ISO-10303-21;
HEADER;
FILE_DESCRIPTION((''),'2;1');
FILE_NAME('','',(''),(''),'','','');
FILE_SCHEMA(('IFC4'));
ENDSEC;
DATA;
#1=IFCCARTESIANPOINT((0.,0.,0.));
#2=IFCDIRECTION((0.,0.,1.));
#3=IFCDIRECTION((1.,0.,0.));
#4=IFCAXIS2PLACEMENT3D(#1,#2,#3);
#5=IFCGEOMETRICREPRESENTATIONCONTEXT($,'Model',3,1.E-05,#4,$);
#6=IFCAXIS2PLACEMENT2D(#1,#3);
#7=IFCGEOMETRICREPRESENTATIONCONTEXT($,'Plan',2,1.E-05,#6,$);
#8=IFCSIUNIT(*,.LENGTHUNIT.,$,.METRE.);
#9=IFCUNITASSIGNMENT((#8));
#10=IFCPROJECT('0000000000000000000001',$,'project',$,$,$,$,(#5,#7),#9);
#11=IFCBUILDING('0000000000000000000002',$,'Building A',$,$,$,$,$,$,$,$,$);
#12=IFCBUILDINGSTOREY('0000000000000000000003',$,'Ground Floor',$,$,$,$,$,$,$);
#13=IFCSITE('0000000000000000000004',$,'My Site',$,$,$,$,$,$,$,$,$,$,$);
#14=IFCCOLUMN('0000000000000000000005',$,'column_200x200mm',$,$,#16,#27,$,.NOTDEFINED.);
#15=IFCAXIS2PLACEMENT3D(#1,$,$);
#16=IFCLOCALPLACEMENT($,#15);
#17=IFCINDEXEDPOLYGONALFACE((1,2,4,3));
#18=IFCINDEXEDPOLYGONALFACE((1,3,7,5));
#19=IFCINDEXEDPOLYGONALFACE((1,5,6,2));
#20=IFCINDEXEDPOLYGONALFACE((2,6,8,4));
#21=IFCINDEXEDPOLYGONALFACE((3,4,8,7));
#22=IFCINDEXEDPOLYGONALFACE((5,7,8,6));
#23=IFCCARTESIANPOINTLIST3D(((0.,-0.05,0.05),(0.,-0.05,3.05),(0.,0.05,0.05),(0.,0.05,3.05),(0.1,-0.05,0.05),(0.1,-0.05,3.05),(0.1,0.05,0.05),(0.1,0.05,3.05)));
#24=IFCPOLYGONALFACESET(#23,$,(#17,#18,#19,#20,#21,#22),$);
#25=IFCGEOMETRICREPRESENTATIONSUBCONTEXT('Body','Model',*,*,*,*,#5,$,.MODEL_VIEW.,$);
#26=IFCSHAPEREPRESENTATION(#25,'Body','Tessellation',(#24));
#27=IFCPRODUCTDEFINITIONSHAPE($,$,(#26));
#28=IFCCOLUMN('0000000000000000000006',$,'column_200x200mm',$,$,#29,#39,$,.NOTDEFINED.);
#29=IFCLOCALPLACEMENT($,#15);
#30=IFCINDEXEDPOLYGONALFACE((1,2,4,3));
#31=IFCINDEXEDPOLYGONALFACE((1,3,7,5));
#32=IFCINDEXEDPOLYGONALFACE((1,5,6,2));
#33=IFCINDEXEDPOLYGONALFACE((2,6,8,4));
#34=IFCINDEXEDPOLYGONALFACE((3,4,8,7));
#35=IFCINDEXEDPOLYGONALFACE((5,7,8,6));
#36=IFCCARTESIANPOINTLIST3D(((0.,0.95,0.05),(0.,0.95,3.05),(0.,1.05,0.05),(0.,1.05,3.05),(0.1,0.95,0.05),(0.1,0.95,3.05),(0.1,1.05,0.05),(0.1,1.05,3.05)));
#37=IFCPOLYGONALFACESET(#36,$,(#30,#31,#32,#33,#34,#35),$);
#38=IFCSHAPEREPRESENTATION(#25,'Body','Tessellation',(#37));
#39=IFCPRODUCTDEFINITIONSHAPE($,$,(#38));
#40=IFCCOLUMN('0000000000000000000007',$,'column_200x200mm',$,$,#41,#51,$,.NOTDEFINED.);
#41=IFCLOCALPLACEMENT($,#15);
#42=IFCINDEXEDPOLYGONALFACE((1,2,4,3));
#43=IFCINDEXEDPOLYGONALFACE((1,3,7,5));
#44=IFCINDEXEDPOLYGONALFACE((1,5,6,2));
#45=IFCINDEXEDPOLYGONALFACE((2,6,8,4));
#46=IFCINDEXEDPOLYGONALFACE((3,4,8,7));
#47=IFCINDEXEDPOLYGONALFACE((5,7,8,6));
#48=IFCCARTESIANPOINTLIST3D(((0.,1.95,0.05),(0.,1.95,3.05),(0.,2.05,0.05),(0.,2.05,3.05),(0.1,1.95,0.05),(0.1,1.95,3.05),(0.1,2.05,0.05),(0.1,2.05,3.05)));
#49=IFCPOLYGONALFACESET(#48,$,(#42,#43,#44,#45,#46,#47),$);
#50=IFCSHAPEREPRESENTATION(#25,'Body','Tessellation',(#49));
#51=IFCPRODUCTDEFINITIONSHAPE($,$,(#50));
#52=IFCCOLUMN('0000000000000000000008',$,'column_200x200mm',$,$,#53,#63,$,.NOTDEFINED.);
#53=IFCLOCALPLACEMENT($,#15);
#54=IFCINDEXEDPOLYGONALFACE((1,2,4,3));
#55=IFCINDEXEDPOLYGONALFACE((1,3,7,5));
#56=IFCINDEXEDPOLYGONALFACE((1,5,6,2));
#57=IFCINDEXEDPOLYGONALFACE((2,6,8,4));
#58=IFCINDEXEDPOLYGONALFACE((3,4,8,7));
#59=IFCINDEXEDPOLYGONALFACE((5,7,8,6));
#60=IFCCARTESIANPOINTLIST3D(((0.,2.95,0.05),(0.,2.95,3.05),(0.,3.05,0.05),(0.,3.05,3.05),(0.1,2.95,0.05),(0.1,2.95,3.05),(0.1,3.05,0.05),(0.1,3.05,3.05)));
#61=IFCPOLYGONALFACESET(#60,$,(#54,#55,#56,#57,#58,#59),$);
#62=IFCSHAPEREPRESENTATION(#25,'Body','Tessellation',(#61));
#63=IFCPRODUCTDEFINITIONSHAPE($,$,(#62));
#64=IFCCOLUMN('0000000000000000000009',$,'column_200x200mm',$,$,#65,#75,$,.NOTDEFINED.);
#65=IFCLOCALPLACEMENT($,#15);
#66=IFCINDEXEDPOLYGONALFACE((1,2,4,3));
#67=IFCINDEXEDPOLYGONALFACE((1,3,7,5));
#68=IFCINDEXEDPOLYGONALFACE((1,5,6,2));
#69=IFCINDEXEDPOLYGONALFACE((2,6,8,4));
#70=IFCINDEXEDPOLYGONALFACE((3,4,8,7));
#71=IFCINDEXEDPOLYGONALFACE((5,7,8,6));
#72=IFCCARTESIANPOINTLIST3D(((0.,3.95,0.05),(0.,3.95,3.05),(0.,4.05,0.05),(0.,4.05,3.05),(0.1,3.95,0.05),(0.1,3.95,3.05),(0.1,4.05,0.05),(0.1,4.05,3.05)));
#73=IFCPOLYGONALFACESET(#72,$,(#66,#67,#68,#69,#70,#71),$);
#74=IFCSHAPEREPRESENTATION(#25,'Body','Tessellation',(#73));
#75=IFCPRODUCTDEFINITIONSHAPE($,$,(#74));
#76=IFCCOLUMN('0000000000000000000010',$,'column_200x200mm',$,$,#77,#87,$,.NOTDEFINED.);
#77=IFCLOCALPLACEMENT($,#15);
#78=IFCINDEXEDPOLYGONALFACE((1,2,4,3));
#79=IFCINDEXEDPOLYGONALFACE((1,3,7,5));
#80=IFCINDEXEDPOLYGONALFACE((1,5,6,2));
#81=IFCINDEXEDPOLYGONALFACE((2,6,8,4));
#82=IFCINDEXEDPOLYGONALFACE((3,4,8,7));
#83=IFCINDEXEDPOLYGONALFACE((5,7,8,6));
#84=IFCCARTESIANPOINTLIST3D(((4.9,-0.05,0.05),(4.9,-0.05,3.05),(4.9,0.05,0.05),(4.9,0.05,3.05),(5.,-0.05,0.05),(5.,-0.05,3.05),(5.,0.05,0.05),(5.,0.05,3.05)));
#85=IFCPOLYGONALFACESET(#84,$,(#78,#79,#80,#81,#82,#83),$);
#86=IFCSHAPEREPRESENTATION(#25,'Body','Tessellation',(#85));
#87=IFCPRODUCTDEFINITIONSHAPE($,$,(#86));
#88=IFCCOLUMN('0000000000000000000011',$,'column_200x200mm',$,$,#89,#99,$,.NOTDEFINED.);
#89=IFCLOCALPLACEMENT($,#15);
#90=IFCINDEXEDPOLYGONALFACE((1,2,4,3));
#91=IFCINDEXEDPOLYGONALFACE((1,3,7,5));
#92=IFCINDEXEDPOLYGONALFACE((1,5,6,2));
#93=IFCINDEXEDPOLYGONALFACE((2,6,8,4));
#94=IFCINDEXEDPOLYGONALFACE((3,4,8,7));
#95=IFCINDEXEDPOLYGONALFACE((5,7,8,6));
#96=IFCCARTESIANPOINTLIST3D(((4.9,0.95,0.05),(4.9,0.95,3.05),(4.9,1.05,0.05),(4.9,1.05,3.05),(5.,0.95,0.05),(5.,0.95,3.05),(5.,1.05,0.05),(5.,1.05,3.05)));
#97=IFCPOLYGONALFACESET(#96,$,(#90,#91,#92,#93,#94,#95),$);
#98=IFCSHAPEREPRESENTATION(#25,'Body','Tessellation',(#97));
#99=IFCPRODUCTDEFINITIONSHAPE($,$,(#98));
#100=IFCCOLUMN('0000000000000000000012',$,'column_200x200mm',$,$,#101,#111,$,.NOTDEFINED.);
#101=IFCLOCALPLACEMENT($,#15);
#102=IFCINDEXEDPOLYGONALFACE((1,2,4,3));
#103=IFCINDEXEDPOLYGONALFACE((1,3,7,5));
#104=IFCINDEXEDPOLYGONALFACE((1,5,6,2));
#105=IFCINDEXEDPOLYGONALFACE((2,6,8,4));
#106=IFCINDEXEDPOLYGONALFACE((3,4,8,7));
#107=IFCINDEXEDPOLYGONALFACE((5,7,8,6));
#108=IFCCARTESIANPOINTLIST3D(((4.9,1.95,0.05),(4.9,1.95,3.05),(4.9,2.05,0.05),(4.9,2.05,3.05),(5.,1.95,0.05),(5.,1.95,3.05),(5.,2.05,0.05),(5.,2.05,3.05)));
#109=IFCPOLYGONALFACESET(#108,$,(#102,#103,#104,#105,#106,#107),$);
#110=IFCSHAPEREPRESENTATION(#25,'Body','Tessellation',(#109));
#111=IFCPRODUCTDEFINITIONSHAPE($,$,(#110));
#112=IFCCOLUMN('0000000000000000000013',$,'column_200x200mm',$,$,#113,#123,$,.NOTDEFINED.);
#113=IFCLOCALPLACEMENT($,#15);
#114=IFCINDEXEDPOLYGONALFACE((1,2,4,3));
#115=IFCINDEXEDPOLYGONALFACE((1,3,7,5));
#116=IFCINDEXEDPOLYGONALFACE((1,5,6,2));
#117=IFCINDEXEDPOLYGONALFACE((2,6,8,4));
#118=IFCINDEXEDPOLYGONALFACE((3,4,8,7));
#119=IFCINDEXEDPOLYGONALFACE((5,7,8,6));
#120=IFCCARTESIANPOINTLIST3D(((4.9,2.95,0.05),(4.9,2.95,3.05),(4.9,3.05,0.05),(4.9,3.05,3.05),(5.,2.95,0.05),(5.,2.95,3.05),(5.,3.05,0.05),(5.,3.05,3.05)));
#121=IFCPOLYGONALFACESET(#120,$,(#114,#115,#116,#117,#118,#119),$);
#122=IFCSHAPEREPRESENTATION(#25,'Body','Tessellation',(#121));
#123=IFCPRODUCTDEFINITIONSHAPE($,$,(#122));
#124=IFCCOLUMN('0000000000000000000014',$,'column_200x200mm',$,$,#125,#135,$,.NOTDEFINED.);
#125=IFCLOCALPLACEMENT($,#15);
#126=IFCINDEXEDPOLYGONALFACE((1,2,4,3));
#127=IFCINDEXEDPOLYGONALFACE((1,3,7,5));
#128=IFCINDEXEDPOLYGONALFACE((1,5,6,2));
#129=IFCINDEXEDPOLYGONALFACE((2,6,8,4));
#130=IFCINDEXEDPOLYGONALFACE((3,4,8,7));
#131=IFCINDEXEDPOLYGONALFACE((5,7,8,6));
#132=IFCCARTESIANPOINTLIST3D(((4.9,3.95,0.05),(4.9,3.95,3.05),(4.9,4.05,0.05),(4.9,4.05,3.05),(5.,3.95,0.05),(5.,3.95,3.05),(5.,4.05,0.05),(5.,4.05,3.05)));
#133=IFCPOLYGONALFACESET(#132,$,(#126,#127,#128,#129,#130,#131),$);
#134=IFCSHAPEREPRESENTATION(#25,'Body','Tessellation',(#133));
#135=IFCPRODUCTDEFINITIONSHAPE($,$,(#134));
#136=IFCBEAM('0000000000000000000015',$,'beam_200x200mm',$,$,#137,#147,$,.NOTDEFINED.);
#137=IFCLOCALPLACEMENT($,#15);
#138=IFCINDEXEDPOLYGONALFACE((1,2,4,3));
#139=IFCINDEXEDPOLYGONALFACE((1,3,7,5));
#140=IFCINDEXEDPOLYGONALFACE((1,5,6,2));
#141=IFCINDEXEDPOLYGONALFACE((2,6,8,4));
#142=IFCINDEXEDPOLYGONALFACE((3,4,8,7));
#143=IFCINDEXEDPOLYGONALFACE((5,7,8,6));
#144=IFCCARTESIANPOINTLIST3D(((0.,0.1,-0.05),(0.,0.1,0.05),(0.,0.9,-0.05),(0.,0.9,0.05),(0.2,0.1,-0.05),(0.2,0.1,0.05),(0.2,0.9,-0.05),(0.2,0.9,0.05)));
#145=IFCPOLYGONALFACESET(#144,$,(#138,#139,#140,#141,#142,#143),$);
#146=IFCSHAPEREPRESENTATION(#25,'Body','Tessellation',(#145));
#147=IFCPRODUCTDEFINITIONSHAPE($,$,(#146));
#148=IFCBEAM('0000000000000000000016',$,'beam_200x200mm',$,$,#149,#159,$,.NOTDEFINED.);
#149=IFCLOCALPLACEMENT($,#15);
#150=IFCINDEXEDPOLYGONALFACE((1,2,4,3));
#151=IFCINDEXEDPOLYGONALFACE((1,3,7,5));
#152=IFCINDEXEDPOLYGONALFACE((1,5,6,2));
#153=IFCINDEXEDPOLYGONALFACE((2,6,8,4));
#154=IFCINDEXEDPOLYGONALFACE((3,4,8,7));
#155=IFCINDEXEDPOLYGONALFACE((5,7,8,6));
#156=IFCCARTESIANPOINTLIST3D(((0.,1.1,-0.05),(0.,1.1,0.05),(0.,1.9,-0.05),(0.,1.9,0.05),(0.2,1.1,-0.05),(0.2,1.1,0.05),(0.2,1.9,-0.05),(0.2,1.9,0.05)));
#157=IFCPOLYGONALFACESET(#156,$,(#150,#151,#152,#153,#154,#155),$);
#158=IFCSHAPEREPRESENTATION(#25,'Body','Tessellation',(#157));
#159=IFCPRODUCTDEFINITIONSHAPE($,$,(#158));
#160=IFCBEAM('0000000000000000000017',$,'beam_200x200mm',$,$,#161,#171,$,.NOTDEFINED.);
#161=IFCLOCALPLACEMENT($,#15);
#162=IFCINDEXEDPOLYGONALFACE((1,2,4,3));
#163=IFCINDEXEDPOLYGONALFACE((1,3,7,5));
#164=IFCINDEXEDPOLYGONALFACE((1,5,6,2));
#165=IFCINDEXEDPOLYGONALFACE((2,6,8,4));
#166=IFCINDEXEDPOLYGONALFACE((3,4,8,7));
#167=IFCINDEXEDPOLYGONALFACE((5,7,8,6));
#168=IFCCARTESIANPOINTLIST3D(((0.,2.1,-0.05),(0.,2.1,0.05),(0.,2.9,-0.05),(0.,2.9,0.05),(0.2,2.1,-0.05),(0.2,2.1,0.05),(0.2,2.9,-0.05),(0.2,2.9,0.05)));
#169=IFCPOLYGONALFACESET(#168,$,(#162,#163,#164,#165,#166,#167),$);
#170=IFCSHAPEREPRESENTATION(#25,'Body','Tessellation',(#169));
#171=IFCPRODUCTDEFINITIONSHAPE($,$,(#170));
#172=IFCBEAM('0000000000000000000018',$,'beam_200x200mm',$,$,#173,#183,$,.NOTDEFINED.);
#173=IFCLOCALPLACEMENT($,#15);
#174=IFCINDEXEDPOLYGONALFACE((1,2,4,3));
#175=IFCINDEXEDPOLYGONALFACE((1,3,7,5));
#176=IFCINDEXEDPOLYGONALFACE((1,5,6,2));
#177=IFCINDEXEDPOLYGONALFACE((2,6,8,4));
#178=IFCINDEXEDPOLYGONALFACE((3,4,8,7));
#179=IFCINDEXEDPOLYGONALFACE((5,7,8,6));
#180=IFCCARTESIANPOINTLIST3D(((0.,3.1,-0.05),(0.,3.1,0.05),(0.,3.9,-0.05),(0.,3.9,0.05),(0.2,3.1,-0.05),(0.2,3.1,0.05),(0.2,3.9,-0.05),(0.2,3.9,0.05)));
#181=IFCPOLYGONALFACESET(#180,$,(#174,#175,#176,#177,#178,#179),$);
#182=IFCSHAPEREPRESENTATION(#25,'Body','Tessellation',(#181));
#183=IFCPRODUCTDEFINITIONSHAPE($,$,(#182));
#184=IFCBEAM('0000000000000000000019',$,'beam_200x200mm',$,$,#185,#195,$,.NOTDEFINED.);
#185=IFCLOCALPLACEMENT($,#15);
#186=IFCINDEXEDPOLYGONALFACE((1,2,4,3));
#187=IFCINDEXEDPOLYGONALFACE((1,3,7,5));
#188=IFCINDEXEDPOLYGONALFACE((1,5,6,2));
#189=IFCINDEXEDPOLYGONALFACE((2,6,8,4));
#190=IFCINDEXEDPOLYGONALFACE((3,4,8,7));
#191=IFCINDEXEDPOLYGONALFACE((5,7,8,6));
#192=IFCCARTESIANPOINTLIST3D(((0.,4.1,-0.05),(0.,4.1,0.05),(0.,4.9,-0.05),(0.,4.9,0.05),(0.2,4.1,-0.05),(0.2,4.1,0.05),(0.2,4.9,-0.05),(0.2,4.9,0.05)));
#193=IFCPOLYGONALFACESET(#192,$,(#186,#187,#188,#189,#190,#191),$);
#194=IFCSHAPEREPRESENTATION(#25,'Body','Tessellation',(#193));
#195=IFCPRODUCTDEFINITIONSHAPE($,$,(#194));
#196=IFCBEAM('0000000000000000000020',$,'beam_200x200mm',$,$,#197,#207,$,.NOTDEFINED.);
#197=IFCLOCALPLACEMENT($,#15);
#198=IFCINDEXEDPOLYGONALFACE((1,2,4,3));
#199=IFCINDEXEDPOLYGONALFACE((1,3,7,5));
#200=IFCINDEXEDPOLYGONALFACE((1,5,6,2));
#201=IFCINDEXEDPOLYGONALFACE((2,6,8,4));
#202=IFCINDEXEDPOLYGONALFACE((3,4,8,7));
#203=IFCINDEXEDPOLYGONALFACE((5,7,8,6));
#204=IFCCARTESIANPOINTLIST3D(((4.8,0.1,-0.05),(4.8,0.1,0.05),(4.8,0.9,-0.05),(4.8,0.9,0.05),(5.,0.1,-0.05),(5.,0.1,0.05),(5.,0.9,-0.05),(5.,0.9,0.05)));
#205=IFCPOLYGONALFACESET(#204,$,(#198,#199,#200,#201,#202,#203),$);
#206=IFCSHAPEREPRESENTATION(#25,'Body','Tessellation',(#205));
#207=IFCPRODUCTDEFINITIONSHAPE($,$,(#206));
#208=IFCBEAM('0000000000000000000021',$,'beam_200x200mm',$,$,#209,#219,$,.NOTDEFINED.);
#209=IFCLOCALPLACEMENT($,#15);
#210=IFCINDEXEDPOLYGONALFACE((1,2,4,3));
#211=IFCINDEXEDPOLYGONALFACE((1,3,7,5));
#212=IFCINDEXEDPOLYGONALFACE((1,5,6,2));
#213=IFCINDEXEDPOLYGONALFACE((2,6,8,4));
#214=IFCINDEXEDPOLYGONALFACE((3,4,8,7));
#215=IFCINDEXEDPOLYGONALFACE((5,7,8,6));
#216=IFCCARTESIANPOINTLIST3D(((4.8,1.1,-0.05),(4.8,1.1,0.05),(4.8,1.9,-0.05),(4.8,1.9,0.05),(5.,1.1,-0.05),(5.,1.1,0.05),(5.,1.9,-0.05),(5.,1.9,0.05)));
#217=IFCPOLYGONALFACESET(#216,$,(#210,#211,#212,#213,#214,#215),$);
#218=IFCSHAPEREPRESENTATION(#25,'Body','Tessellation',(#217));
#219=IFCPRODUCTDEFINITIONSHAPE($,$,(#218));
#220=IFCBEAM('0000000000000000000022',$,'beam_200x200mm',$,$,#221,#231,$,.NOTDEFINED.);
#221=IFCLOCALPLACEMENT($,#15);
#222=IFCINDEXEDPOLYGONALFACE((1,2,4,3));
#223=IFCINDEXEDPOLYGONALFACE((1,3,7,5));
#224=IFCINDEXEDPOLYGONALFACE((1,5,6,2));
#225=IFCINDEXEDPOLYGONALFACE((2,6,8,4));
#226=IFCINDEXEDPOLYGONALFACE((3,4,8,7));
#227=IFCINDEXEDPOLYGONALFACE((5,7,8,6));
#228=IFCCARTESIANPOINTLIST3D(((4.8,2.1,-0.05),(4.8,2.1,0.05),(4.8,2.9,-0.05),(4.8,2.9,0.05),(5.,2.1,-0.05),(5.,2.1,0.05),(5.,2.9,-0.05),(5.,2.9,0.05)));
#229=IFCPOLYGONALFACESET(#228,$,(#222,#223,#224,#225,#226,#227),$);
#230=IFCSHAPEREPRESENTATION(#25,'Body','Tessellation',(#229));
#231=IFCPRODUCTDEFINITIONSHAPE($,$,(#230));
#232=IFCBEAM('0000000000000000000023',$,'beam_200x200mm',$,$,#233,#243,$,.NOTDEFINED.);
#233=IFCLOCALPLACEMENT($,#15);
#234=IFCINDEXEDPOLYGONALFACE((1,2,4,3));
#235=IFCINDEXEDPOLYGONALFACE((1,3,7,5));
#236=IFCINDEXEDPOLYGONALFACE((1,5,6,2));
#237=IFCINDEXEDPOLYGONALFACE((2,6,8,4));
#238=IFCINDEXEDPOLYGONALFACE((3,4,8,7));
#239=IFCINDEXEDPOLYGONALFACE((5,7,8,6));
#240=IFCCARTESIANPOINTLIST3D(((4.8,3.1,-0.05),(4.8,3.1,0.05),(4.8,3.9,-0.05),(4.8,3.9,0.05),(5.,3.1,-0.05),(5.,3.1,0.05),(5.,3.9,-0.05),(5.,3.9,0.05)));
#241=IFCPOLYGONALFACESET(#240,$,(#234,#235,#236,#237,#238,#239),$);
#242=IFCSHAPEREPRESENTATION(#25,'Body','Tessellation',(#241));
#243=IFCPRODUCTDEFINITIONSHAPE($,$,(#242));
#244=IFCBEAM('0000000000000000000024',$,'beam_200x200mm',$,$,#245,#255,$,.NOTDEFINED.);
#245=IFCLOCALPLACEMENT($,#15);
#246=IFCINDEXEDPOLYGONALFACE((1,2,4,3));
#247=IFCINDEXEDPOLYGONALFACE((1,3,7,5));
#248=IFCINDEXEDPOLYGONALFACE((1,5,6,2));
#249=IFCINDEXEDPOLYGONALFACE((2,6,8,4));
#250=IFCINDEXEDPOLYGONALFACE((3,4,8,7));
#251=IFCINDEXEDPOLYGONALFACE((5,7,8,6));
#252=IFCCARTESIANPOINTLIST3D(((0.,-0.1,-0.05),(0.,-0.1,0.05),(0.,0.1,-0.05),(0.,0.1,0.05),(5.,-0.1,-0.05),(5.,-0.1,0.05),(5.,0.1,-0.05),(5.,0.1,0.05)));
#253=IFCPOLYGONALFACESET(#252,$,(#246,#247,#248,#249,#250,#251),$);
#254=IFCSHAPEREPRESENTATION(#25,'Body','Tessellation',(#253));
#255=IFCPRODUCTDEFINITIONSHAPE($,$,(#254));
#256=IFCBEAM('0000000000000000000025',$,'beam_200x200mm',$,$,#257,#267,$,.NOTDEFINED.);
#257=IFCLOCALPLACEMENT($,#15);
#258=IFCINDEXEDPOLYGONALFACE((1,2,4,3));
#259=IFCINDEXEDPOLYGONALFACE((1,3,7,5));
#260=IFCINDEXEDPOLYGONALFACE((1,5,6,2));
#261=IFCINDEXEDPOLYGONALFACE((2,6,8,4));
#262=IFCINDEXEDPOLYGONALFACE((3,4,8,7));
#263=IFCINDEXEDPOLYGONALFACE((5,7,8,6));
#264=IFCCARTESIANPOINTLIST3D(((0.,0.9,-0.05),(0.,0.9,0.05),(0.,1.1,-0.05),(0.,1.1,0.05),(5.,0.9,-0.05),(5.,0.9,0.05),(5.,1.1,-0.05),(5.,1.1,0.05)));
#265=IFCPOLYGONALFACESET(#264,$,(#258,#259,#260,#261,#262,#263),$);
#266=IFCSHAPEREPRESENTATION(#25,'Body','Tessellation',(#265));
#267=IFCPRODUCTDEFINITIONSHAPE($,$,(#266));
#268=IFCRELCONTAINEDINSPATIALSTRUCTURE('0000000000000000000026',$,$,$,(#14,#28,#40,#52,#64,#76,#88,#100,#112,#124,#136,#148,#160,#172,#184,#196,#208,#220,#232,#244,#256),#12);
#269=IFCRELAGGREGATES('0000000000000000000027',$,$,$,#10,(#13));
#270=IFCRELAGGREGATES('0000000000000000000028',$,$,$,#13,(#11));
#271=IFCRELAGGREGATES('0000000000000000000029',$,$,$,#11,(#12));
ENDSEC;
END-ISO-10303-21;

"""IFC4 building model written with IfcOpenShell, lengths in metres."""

from ifc_helpers import new_model, si_unit, frame, frame_2d, origin_with_axes, place, context, subcontext, project, spatial, rectangle, extrude, element, save


model = new_model("IFC4")

# Units and contexts
model_context = context("Model", 3, precision=1e-05, world=origin_with_axes())
plan_context = context("Plan", 2, precision=1e-05, world=frame_2d((0.0, 0.0, 0.0), x_axis=(1.0, 0.0, 0.0)))
body_context = subcontext(model_context, "Body", "Model", "MODEL_VIEW")
ifc_project = project(units=[si_unit("LENGTHUNIT", "METRE")], contexts=[model_context, plan_context])

# Site, building, storey
site = spatial("IfcSite", under=ifc_project, Name="My Site")
building = spatial("IfcBuilding", under=site, Name="Building A")
storey = spatial("IfcBuildingStorey", under=building, Name="Ground Floor")

# Columns
for number, where, z_axis, x_axis, name in (
    (1, (0.05, 0.0, 0.05), (0.0, 0.0, 1.0), (1.0, 0.0, 0.0), "column_200x200mm"),
    (2, (0.05, 1.0, 0.05), (0.0, 0.0, 1.0), (1.0, 0.0, 0.0), "column_200x200mm"),
    (3, (0.05, 2.0, 0.05), (0.0, 0.0, 1.0), (1.0, 0.0, 0.0), "column_200x200mm"),
    (4, (0.05, 3.0, 0.05), (0.0, 0.0, 1.0), (1.0, 0.0, 0.0), "column_200x200mm"),
    (5, (0.05, 4.0, 0.05), (0.0, 0.0, 1.0), (1.0, 0.0, 0.0), "column_200x200mm"),
    (6, (4.95, 0.0, 0.05), (0.0, 0.0, 1.0), (1.0, 0.0, 0.0), "column_200x200mm"),
    (7, (4.95, 1.0, 0.05), (0.0, 0.0, 1.0), (1.0, 0.0, 0.0), "column_200x200mm"),
    (8, (4.95, 2.0, 0.05), (0.0, 0.0, 1.0), (1.0, 0.0, 0.0), "column_200x200mm"),
    (9, (4.95, 3.0, 0.05), (0.0, 0.0, 1.0), (1.0, 0.0, 0.0), "column_200x200mm"),
    (10, (4.95, 4.0, 0.05), (0.0, 0.0, 1.0), (1.0, 0.0, 0.0), "column_200x200mm"),
):
    element("IfcColumn", number, at=place(None, frame(where, z_axis=z_axis, x_axis=x_axis)), inside=storey, Name=name, PredefinedType="NOTDEFINED", context=body_context, shape_type="SweptSolid", body=[
        extrude(rectangle(XDim=0.1, YDim=0.1), origin_with_axes(), (0.0, 0.0, 1.0), 3.0),
    ])

# Beams
for number, where, z_axis, x_axis, name in (
    (11, (0.1, 0.1, 0.0), (0.0, 1.0, 0.0), (0.0, 1.0, 1.0), "beam_200x200mm"),
    (12, (0.1, 1.1, 0.0), (0.0, 1.0, 0.0), (0.0, 1.0, 1.0), "beam_200x200mm"),
    (13, (0.1, 2.1, 0.0), (0.0, 1.0, 0.0), (0.0, 1.0, 1.0), "beam_200x200mm"),
    (14, (0.1, 3.1, 0.0), (0.0, 1.0, 0.0), (0.0, 1.0, 1.0), "beam_200x200mm"),
    (15, (0.1, 4.1, 0.0), (0.0, 1.0, 0.0), (0.0, 1.0, 1.0), "beam_200x200mm"),
    (16, (4.9, 0.1, 0.0), (0.0, 1.0, 0.0), (0.0, 1.0, 1.0), "beam_200x200mm"),
    (17, (4.9, 1.1, 0.0), (0.0, 1.0, 0.0), (0.0, 1.0, 1.0), "beam_200x200mm"),
    (18, (4.9, 2.1, 0.0), (0.0, 1.0, 0.0), (0.0, 1.0, 1.0), "beam_200x200mm"),
    (19, (4.9, 3.1, 0.0), (0.0, 1.0, 0.0), (0.0, 1.0, 1.0), "beam_200x200mm"),
):
    element("IfcBeam", number, at=place(None, frame(where, z_axis=z_axis, x_axis=x_axis)), inside=storey, Name=name, PredefinedType="NOTDEFINED", context=body_context, shape_type="SweptSolid", body=[
        extrude(rectangle(XDim=0.1, YDim=0.2), origin_with_axes(), (0.0, 0.0, 1.0), 0.8),
    ])
for number, where, z_axis, x_axis, name in (
    (20, (0.0, 0.0, 0.0), (1.0, 0.0, 0.0), (0.0, 0.0, 1.0), "beam_200x200mm"),
    (21, (0.0, 1.0, 0.0), (1.0, 0.0, 0.0), (0.0, 0.0, 1.0), "beam_200x200mm"),
):
    element("IfcBeam", number, at=place(None, frame(where, z_axis=z_axis, x_axis=x_axis)), inside=storey, Name=name, PredefinedType="NOTDEFINED", context=body_context, shape_type="SweptSolid", body=[
        extrude(rectangle(XDim=0.1, YDim=0.2), origin_with_axes(), (0.0, 0.0, 1.0), 5.0),
    ])

save(model, "model.ifc")
